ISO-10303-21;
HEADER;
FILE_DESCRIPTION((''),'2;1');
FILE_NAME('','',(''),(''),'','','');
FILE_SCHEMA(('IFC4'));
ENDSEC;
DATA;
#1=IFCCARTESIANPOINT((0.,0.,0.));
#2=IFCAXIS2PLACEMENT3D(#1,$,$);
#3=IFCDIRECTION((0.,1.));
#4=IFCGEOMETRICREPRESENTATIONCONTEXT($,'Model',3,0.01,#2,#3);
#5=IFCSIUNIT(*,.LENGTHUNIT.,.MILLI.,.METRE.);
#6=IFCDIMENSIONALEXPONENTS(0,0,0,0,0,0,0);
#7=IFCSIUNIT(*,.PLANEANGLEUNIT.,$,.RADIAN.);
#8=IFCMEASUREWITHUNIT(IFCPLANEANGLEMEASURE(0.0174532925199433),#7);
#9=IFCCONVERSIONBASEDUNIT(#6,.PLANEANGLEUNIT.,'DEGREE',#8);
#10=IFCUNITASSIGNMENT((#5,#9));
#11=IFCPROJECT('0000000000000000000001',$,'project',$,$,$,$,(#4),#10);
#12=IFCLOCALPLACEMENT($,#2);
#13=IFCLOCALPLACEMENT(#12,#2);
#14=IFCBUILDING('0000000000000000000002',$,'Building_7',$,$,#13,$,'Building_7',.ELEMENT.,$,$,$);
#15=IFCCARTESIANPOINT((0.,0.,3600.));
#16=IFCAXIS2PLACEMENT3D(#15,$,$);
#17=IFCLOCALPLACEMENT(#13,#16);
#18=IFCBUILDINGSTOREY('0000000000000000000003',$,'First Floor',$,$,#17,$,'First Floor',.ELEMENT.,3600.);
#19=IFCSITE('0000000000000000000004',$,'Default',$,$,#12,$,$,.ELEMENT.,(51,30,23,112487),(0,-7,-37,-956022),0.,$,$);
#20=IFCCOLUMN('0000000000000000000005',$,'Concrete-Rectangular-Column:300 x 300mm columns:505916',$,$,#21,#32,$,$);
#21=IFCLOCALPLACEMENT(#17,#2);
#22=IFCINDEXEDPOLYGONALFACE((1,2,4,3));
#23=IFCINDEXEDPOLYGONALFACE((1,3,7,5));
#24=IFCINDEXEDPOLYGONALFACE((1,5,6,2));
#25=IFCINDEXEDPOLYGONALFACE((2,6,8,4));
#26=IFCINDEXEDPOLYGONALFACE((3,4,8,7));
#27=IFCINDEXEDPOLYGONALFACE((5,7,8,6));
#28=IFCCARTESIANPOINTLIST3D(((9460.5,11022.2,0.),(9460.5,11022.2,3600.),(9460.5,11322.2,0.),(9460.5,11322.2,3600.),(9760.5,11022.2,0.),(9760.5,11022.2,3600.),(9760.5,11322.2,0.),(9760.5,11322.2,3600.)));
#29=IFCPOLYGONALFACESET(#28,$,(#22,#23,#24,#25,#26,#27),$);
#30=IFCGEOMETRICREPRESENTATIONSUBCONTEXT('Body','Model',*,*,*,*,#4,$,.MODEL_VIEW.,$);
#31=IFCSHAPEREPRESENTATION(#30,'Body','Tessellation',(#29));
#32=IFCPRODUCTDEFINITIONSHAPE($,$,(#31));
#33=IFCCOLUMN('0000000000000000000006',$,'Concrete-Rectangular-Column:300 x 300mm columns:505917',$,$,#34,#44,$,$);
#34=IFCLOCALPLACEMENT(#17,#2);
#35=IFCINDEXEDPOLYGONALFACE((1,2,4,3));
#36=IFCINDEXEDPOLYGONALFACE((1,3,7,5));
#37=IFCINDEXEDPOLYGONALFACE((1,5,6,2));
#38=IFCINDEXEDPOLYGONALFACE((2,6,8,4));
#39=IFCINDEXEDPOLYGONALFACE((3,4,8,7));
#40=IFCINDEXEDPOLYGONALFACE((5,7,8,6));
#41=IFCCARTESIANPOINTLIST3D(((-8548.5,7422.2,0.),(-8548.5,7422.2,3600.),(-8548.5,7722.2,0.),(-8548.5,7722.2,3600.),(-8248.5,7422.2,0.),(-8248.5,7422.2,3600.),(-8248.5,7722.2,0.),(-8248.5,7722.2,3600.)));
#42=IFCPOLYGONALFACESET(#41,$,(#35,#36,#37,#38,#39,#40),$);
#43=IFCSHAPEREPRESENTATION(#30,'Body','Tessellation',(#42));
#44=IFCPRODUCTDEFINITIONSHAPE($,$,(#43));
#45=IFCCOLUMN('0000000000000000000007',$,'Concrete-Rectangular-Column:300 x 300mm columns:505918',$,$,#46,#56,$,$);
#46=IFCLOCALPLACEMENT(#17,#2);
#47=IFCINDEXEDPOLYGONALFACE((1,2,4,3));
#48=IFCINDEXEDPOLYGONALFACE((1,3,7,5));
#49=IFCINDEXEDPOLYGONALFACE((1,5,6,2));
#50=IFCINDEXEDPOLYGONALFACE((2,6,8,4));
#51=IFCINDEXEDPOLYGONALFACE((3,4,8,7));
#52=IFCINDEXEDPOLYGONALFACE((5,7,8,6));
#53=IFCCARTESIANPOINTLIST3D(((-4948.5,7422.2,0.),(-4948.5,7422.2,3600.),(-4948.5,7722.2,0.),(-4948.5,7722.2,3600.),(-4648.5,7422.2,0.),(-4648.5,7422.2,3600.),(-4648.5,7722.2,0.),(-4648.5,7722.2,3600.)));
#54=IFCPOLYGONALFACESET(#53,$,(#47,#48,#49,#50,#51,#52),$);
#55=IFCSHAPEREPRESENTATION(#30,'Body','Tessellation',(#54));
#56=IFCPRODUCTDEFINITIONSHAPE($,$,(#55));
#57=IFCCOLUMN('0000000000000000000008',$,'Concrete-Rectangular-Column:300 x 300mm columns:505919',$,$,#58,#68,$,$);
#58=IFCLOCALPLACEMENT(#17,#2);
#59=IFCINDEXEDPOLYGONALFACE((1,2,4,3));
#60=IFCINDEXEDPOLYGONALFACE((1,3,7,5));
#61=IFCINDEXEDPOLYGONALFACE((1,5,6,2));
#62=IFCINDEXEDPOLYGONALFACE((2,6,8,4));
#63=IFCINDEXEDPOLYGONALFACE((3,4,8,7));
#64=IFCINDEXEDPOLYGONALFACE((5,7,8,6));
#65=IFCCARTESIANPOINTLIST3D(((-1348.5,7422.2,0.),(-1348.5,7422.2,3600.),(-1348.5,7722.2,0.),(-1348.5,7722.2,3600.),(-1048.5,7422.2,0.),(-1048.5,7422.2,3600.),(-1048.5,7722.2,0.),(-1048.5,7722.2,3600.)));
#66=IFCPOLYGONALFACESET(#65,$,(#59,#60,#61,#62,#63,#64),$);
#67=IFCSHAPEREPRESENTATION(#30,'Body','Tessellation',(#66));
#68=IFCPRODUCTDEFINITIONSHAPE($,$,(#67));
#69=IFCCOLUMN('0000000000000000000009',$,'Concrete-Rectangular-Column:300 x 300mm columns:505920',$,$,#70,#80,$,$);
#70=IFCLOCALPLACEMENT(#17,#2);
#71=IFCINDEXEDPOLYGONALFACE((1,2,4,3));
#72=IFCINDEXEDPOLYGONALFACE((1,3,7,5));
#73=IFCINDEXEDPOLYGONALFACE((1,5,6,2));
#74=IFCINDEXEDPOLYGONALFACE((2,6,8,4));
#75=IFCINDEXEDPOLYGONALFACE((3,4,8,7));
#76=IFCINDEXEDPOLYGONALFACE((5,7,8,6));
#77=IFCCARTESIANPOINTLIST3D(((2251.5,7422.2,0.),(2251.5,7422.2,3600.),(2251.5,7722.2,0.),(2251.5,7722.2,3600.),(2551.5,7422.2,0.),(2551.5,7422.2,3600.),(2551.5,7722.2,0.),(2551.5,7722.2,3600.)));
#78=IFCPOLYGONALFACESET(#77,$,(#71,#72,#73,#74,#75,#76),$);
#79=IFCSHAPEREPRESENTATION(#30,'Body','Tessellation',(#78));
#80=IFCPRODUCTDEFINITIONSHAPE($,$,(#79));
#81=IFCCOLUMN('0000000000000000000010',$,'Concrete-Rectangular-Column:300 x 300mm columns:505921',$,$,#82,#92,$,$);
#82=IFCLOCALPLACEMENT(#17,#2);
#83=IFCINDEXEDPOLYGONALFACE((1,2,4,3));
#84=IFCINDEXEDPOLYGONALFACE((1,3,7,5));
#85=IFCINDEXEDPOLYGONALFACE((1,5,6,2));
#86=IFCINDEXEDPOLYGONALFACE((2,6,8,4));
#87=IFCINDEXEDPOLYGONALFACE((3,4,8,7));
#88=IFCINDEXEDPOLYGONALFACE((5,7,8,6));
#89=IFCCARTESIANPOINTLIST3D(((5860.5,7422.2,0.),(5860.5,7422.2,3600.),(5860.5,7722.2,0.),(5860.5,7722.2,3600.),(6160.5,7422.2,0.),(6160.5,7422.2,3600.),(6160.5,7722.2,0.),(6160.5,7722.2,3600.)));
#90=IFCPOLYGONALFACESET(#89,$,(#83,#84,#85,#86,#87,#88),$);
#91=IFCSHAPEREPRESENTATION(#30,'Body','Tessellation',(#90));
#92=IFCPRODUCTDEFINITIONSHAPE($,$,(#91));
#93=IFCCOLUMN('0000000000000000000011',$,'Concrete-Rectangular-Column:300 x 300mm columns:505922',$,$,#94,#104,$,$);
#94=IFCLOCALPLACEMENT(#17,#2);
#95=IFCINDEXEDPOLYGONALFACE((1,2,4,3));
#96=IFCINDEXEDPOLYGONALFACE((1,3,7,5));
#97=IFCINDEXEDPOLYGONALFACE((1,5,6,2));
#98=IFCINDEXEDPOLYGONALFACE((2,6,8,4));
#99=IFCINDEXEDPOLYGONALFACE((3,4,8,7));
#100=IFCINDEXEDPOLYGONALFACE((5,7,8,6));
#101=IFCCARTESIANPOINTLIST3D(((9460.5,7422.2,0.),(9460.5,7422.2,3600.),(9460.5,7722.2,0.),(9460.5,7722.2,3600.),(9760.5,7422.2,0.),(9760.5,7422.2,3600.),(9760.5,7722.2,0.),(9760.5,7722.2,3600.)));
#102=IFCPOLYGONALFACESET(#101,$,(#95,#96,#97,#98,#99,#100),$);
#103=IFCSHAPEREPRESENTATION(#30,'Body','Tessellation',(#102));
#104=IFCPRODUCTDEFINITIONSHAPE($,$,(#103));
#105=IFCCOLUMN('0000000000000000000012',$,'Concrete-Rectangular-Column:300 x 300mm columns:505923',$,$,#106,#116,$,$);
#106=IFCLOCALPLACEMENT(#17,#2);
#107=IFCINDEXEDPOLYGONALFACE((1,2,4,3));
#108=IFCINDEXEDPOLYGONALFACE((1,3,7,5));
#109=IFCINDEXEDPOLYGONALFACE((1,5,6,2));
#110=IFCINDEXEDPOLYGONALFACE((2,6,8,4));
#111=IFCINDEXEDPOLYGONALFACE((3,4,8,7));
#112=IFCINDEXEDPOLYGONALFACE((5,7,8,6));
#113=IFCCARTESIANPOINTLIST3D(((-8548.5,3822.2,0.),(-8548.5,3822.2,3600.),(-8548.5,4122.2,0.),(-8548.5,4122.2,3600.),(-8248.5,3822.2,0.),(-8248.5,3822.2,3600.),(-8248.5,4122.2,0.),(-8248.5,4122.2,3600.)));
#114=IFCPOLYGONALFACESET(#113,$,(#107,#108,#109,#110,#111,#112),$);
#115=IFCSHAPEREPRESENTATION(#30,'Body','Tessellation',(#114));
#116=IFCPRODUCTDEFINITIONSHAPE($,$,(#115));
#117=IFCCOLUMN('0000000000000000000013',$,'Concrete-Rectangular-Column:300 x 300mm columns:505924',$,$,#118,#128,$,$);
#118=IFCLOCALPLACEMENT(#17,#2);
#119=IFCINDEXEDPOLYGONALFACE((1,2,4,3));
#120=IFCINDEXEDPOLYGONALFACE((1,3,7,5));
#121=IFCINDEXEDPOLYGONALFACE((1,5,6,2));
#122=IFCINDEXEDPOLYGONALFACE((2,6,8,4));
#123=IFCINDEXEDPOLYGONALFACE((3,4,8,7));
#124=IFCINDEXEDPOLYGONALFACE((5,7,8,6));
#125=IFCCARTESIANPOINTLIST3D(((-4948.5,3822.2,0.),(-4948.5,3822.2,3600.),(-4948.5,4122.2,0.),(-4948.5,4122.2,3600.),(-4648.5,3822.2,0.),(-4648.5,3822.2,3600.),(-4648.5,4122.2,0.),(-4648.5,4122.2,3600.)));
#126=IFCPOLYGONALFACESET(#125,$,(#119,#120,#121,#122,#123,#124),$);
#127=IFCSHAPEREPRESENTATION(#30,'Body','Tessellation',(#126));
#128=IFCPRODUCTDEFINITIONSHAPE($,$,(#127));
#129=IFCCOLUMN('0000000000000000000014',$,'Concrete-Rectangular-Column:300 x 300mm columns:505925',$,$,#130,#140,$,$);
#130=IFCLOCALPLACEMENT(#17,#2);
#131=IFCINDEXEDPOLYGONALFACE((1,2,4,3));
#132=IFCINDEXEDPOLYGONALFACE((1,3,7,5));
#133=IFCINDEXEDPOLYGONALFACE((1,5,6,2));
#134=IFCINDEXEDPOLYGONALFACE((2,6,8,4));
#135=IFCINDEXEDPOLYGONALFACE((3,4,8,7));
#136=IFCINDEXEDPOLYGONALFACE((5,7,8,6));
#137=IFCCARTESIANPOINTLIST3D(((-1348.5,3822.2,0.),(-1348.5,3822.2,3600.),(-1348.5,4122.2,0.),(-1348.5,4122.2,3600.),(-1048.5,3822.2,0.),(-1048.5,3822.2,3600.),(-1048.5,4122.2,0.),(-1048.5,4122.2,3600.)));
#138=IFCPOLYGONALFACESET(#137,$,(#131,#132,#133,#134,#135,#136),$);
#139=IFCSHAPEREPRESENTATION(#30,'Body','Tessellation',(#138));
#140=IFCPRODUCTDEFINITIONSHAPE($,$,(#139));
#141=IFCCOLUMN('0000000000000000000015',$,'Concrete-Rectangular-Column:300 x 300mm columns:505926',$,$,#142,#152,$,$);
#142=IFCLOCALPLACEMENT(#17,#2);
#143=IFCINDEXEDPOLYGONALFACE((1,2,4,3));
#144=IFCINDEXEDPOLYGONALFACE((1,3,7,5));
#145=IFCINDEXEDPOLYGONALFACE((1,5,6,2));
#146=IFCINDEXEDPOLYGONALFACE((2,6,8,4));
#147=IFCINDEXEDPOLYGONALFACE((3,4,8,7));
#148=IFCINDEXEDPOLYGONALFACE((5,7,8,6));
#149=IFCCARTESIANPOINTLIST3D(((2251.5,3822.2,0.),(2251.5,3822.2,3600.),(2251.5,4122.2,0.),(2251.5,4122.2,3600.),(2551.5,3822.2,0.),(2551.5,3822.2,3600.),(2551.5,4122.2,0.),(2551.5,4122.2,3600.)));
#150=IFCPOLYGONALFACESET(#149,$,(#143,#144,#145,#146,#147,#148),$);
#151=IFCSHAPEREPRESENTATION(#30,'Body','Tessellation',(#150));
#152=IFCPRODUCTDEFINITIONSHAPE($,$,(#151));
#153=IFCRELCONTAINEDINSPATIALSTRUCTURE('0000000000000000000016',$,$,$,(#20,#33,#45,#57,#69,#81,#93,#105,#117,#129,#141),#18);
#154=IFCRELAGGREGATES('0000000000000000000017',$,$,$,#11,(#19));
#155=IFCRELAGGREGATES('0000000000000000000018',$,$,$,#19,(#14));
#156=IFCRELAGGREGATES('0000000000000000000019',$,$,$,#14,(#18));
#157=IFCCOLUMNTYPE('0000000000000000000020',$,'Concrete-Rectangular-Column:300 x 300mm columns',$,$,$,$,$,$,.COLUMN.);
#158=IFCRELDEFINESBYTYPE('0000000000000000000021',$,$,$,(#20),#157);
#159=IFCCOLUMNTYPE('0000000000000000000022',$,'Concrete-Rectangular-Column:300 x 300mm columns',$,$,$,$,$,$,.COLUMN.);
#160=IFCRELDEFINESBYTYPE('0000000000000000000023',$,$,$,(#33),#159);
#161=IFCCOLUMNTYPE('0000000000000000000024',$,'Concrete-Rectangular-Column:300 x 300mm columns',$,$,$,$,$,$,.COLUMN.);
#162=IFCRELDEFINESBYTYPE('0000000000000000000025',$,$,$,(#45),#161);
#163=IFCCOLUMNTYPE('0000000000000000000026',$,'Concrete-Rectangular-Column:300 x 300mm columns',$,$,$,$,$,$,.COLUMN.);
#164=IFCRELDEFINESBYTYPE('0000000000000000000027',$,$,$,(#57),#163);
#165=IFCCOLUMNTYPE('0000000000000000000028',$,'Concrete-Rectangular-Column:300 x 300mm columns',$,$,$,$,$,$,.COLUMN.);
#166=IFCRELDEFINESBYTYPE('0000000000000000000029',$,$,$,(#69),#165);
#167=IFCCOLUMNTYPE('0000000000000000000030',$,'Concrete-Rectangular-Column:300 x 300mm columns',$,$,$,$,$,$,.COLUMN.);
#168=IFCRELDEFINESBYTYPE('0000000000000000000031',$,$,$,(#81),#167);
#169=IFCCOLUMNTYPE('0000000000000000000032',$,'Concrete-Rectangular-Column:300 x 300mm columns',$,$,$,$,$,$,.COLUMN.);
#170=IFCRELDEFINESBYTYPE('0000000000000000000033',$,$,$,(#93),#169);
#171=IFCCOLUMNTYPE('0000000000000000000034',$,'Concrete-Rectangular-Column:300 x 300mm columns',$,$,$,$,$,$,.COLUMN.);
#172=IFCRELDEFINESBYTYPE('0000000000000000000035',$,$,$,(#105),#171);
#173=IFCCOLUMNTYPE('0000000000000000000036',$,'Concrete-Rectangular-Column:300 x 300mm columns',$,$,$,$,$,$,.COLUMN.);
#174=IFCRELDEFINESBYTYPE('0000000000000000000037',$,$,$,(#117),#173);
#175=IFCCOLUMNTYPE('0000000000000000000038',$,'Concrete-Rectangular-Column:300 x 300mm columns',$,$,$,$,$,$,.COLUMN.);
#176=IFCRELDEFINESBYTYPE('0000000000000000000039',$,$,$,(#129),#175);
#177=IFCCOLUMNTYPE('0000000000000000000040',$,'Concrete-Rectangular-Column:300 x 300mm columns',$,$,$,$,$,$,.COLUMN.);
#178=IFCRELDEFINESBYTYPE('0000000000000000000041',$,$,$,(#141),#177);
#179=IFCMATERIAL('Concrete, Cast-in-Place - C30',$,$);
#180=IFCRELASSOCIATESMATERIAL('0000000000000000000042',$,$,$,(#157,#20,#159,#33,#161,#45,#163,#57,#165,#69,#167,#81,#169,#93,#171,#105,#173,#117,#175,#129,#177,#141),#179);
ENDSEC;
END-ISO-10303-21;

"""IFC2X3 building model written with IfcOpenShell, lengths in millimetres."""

from ifc_helpers import new_model, entity, si_unit, converted_unit, direction, frame, frame_2d, origin, origin_2d_with_axis, place, context, subcontext, project, spatial, rectangle, extrude, source, transform, mapped, material, type_object, type_shapes, element, save


model = new_model("IFC2X3")

# Units and contexts
model_context = context("Model", 3, precision=0.01, world=origin(), true_north=direction((0.0, 1.0)))
body_context = subcontext(model_context, "Body", "Model", "MODEL_VIEW")
ifc_project = project(units=[si_unit("LENGTHUNIT", "METRE", prefix="MILLI"), converted_unit("PLANEANGLEUNIT", "DEGREE", entity("IfcPlaneAngleMeasure", 0.0174532925199433), si_unit("PLANEANGLEUNIT", "RADIAN"), dimensions=[0, 0, 0, 0, 0, 0, 0])], contexts=[model_context])

# Site, building, storey
site_placement = place(None, origin())
site = spatial("IfcSite", under=ifc_project, at=site_placement, Name="Default", CompositionType="ELEMENT", RefLatitude=(51, 30, 23, 112487), RefLongitude=(0, -7, -37, -956022), RefElevation=0.0)
building_placement = place(site_placement, origin())
building = spatial("IfcBuilding", under=site, at=building_placement, Name="Building_7", LongName="Building_7", CompositionType="ELEMENT")
storey_placement = place(building_placement, frame((0.0, 0.0, 3600.0)))
storey = spatial("IfcBuildingStorey", under=building, at=storey_placement, Name="First Floor", LongName="First Floor", CompositionType="ELEMENT", Elevation=3600.0)

# Columns
ifc_material_1 = material(Name="Concrete, Cast-in-Place - C30")
column_type_1 = type_object("IfcColumnType", Name="Concrete-Rectangular-Column:300 x 300mm columns", PredefinedType="COLUMN", material=ifc_material_1)
shared_shape_1 = source(origin(), body_context, "Body", "SweptSolid", [
    extrude(rectangle(XDim=300.0, YDim=300.0, at=frame_2d((0.0, 0.0), x_axis=(1.0, 0.0))), frame((9610.5, 11172.2, 3600.0), z_axis=(0.0, 0.0, 1.0), x_axis=(-1.0, 0.0, 0.0)), (0.0, 0.0, 1.0), 3600.0),
])
type_shapes(column_type_1, [shared_shape_1])
column_1_placement = place(storey_placement, frame((0.0, 0.0, -3600.0)))
element("IfcColumn", 1, at=column_1_placement, inside=storey, type_object=column_type_1, material=ifc_material_1, Name="Concrete-Rectangular-Column:300 x 300mm columns:505916", context=body_context, shape_type="MappedRepresentation", body=[
    mapped(shared_shape_1, transform((0.0, 0.0, 0.0), scale=1.0)),
])
column_type_2 = type_object("IfcColumnType", Name="Concrete-Rectangular-Column:300 x 300mm columns", PredefinedType="COLUMN", material=ifc_material_1)
shared_shape_2 = source(origin(), body_context, "Body", "SweptSolid", [
    extrude(rectangle(XDim=300.0, YDim=300.0, at=frame_2d((0.0, 0.0), x_axis=(1.0, 0.0))), frame((-8398.5, 7572.2, 3600.0), z_axis=(0.0, 0.0, 1.0), x_axis=(-1.0, 0.0, 0.0)), (0.0, 0.0, 1.0), 3600.0),
])
type_shapes(column_type_2, [shared_shape_2])
column_2_placement = place(storey_placement, frame((0.0, 0.0, -3600.0)))
element("IfcColumn", 2, at=column_2_placement, inside=storey, type_object=column_type_2, material=ifc_material_1, Name="Concrete-Rectangular-Column:300 x 300mm columns:505917", context=body_context, shape_type="MappedRepresentation", body=[
    mapped(shared_shape_2, transform((0.0, 0.0, 0.0), scale=1.0)),
])
column_type_3 = type_object("IfcColumnType", Name="Concrete-Rectangular-Column:300 x 300mm columns", PredefinedType="COLUMN", material=ifc_material_1)
shared_shape_3 = source(origin(), body_context, "Body", "SweptSolid", [
    extrude(rectangle(XDim=300.0, YDim=300.0, at=frame_2d((0.0, 0.0), x_axis=(1.0, 0.0))), frame((-4798.5, 7572.2, 3600.0), z_axis=(0.0, 0.0, 1.0), x_axis=(-1.0, 0.0, 0.0)), (0.0, 0.0, 1.0), 3600.0),
])
type_shapes(column_type_3, [shared_shape_3])
column_3_placement = place(storey_placement, frame((0.0, 0.0, -3600.0)))
element("IfcColumn", 3, at=column_3_placement, inside=storey, type_object=column_type_3, material=ifc_material_1, Name="Concrete-Rectangular-Column:300 x 300mm columns:505918", context=body_context, shape_type="MappedRepresentation", body=[
    mapped(shared_shape_3, transform((0.0, 0.0, 0.0), scale=1.0)),
])
column_type_4 = type_object("IfcColumnType", Name="Concrete-Rectangular-Column:300 x 300mm columns", PredefinedType="COLUMN", material=ifc_material_1)
shared_shape_4 = source(origin(), body_context, "Body", "SweptSolid", [
    extrude(rectangle(XDim=300.0, YDim=300.0, at=frame_2d((0.0, 0.0), x_axis=(1.0, 0.0))), frame((-1198.5, 7572.2, 3600.0), z_axis=(0.0, 0.0, 1.0), x_axis=(-1.0, 0.0, 0.0)), (0.0, 0.0, 1.0), 3600.0),
])
type_shapes(column_type_4, [shared_shape_4])
column_4_placement = place(storey_placement, frame((0.0, 0.0, -3600.0)))
element("IfcColumn", 4, at=column_4_placement, inside=storey, type_object=column_type_4, material=ifc_material_1, Name="Concrete-Rectangular-Column:300 x 300mm columns:505919", context=body_context, shape_type="MappedRepresentation", body=[
    mapped(shared_shape_4, transform((0.0, 0.0, 0.0), scale=1.0)),
])
column_type_5 = type_object("IfcColumnType", Name="Concrete-Rectangular-Column:300 x 300mm columns", PredefinedType="COLUMN", material=ifc_material_1)
shared_shape_5 = source(origin(), body_context, "Body", "SweptSolid", [
    extrude(rectangle(XDim=300.0, YDim=300.0, at=frame_2d((0.0, 0.0), x_axis=(1.0, 0.0))), frame((2401.5, 7572.2, 3600.0), z_axis=(0.0, 0.0, 1.0), x_axis=(-1.0, 0.0, 0.0)), (0.0, 0.0, 1.0), 3600.0),
])
type_shapes(column_type_5, [shared_shape_5])
column_5_placement = place(storey_placement, frame((0.0, 0.0, -3600.0)))
element("IfcColumn", 5, at=column_5_placement, inside=storey, type_object=column_type_5, material=ifc_material_1, Name="Concrete-Rectangular-Column:300 x 300mm columns:505920", context=body_context, shape_type="MappedRepresentation", body=[
    mapped(shared_shape_5, transform((0.0, 0.0, 0.0), scale=1.0)),
])
column_type_6 = type_object("IfcColumnType", Name="Concrete-Rectangular-Column:300 x 300mm columns", PredefinedType="COLUMN", material=ifc_material_1)
shared_shape_6 = source(origin(), body_context, "Body", "SweptSolid", [
    extrude(rectangle(XDim=300.0, YDim=300.0, at=frame_2d((0.0, 0.0), x_axis=(1.0, 0.0))), frame((6010.5, 7572.2, 3600.0), z_axis=(0.0, 0.0, 1.0), x_axis=(-1.0, 0.0, 0.0)), (0.0, 0.0, 1.0), 3600.0),
])
type_shapes(column_type_6, [shared_shape_6])
column_6_placement = place(storey_placement, frame((0.0, 0.0, -3600.0)))
element("IfcColumn", 6, at=column_6_placement, inside=storey, type_object=column_type_6, material=ifc_material_1, Name="Concrete-Rectangular-Column:300 x 300mm columns:505921", context=body_context, shape_type="MappedRepresentation", body=[
    mapped(shared_shape_6, transform((0.0, 0.0, 0.0), scale=1.0)),
])
column_type_7 = type_object("IfcColumnType", Name="Concrete-Rectangular-Column:300 x 300mm columns", PredefinedType="COLUMN", material=ifc_material_1)
shared_shape_7 = source(origin(), body_context, "Body", "SweptSolid", [
    extrude(rectangle(XDim=300.0, YDim=300.0, at=frame_2d((0.0, 0.0), x_axis=(1.0, 0.0))), frame((9610.5, 7572.2, 3600.0), z_axis=(0.0, 0.0, 1.0), x_axis=(-1.0, 0.0, 0.0)), (0.0, 0.0, 1.0), 3600.0),
])
type_shapes(column_type_7, [shared_shape_7])
column_7_placement = place(storey_placement, frame((0.0, 0.0, -3600.0)))
element("IfcColumn", 7, at=column_7_placement, inside=storey, type_object=column_type_7, material=ifc_material_1, Name="Concrete-Rectangular-Column:300 x 300mm columns:505922", context=body_context, shape_type="MappedRepresentation", body=[
    mapped(shared_shape_7, transform((0.0, 0.0, 0.0), scale=1.0)),
])
column_type_8 = type_object("IfcColumnType", Name="Concrete-Rectangular-Column:300 x 300mm columns", PredefinedType="COLUMN", material=ifc_material_1)
shared_shape_8 = source(origin(), body_context, "Body", "SweptSolid", [
    extrude(rectangle(XDim=300.0, YDim=300.0, at=frame_2d((0.0, 0.0), x_axis=(1.0, 0.0))), frame((-8398.5, 3972.2, 3600.0), z_axis=(0.0, 0.0, 1.0), x_axis=(-1.0, 0.0, 0.0)), (0.0, 0.0, 1.0), 3600.0),
])
type_shapes(column_type_8, [shared_shape_8])
column_8_placement = place(storey_placement, frame((0.0, 0.0, -3600.0)))
element("IfcColumn", 8, at=column_8_placement, inside=storey, type_object=column_type_8, material=ifc_material_1, Name="Concrete-Rectangular-Column:300 x 300mm columns:505923", context=body_context, shape_type="MappedRepresentation", body=[
    mapped(shared_shape_8, transform((0.0, 0.0, 0.0), scale=1.0)),
])
column_type_9 = type_object("IfcColumnType", Name="Concrete-Rectangular-Column:300 x 300mm columns", PredefinedType="COLUMN", material=ifc_material_1)
shared_shape_9 = source(origin(), body_context, "Body", "SweptSolid", [
    extrude(rectangle(XDim=300.0, YDim=300.0, at=frame_2d((0.0, 0.0), x_axis=(1.0, 0.0))), frame((-4798.5, 3972.2, 3600.0), z_axis=(0.0, 0.0, 1.0), x_axis=(-1.0, 0.0, 0.0)), (0.0, 0.0, 1.0), 3600.0),
])
type_shapes(column_type_9, [shared_shape_9])
column_9_placement = place(storey_placement, frame((0.0, 0.0, -3600.0)))
element("IfcColumn", 9, at=column_9_placement, inside=storey, type_object=column_type_9, material=ifc_material_1, Name="Concrete-Rectangular-Column:300 x 300mm columns:505924", context=body_context, shape_type="MappedRepresentation", body=[
    mapped(shared_shape_9, transform((0.0, 0.0, 0.0), scale=1.0)),
])
column_type_10 = type_object("IfcColumnType", Name="Concrete-Rectangular-Column:300 x 300mm columns", PredefinedType="COLUMN", material=ifc_material_1)
shared_shape_10 = source(origin(), body_context, "Body", "SweptSolid", [
    extrude(rectangle(XDim=300.0, YDim=300.0, at=origin_2d_with_axis()), frame((-1198.5, 3972.2, 3600.0), z_axis=(0.0, 0.0, 1.0), x_axis=(-1.0, 0.0, 0.0)), (0.0, 0.0, 1.0), 3600.0),
])
type_shapes(column_type_10, [shared_shape_10])
column_10_placement = place(storey_placement, frame((0.0, 0.0, -3600.0)))
element("IfcColumn", 10, at=column_10_placement, inside=storey, type_object=column_type_10, material=ifc_material_1, Name="Concrete-Rectangular-Column:300 x 300mm columns:505925", context=body_context, shape_type="MappedRepresentation", body=[
    mapped(shared_shape_10, transform((0.0, 0.0, 0.0), scale=1.0)),
])
column_type_11 = type_object("IfcColumnType", Name="Concrete-Rectangular-Column:300 x 300mm columns", PredefinedType="COLUMN", material=ifc_material_1)
shared_shape_11 = source(origin(), body_context, "Body", "SweptSolid", [
    extrude(rectangle(XDim=300.0, YDim=300.0, at=frame_2d((0.0, 0.0), x_axis=(1.0, 0.0))), frame((2401.5, 3972.2, 3600.0), z_axis=(0.0, 0.0, 1.0), x_axis=(-1.0, 0.0, 0.0)), (0.0, 0.0, 1.0), 3600.0),
])
type_shapes(column_type_11, [shared_shape_11])
column_11_placement = place(storey_placement, frame((0.0, 0.0, -3600.0)))
element("IfcColumn", 11, at=column_11_placement, inside=storey, type_object=column_type_11, material=ifc_material_1, Name="Concrete-Rectangular-Column:300 x 300mm columns:505926", context=body_context, shape_type="MappedRepresentation", body=[
    mapped(shared_shape_11, transform((0.0, 0.0, 0.0), scale=1.0)),
])

save(model, "model.ifc")
